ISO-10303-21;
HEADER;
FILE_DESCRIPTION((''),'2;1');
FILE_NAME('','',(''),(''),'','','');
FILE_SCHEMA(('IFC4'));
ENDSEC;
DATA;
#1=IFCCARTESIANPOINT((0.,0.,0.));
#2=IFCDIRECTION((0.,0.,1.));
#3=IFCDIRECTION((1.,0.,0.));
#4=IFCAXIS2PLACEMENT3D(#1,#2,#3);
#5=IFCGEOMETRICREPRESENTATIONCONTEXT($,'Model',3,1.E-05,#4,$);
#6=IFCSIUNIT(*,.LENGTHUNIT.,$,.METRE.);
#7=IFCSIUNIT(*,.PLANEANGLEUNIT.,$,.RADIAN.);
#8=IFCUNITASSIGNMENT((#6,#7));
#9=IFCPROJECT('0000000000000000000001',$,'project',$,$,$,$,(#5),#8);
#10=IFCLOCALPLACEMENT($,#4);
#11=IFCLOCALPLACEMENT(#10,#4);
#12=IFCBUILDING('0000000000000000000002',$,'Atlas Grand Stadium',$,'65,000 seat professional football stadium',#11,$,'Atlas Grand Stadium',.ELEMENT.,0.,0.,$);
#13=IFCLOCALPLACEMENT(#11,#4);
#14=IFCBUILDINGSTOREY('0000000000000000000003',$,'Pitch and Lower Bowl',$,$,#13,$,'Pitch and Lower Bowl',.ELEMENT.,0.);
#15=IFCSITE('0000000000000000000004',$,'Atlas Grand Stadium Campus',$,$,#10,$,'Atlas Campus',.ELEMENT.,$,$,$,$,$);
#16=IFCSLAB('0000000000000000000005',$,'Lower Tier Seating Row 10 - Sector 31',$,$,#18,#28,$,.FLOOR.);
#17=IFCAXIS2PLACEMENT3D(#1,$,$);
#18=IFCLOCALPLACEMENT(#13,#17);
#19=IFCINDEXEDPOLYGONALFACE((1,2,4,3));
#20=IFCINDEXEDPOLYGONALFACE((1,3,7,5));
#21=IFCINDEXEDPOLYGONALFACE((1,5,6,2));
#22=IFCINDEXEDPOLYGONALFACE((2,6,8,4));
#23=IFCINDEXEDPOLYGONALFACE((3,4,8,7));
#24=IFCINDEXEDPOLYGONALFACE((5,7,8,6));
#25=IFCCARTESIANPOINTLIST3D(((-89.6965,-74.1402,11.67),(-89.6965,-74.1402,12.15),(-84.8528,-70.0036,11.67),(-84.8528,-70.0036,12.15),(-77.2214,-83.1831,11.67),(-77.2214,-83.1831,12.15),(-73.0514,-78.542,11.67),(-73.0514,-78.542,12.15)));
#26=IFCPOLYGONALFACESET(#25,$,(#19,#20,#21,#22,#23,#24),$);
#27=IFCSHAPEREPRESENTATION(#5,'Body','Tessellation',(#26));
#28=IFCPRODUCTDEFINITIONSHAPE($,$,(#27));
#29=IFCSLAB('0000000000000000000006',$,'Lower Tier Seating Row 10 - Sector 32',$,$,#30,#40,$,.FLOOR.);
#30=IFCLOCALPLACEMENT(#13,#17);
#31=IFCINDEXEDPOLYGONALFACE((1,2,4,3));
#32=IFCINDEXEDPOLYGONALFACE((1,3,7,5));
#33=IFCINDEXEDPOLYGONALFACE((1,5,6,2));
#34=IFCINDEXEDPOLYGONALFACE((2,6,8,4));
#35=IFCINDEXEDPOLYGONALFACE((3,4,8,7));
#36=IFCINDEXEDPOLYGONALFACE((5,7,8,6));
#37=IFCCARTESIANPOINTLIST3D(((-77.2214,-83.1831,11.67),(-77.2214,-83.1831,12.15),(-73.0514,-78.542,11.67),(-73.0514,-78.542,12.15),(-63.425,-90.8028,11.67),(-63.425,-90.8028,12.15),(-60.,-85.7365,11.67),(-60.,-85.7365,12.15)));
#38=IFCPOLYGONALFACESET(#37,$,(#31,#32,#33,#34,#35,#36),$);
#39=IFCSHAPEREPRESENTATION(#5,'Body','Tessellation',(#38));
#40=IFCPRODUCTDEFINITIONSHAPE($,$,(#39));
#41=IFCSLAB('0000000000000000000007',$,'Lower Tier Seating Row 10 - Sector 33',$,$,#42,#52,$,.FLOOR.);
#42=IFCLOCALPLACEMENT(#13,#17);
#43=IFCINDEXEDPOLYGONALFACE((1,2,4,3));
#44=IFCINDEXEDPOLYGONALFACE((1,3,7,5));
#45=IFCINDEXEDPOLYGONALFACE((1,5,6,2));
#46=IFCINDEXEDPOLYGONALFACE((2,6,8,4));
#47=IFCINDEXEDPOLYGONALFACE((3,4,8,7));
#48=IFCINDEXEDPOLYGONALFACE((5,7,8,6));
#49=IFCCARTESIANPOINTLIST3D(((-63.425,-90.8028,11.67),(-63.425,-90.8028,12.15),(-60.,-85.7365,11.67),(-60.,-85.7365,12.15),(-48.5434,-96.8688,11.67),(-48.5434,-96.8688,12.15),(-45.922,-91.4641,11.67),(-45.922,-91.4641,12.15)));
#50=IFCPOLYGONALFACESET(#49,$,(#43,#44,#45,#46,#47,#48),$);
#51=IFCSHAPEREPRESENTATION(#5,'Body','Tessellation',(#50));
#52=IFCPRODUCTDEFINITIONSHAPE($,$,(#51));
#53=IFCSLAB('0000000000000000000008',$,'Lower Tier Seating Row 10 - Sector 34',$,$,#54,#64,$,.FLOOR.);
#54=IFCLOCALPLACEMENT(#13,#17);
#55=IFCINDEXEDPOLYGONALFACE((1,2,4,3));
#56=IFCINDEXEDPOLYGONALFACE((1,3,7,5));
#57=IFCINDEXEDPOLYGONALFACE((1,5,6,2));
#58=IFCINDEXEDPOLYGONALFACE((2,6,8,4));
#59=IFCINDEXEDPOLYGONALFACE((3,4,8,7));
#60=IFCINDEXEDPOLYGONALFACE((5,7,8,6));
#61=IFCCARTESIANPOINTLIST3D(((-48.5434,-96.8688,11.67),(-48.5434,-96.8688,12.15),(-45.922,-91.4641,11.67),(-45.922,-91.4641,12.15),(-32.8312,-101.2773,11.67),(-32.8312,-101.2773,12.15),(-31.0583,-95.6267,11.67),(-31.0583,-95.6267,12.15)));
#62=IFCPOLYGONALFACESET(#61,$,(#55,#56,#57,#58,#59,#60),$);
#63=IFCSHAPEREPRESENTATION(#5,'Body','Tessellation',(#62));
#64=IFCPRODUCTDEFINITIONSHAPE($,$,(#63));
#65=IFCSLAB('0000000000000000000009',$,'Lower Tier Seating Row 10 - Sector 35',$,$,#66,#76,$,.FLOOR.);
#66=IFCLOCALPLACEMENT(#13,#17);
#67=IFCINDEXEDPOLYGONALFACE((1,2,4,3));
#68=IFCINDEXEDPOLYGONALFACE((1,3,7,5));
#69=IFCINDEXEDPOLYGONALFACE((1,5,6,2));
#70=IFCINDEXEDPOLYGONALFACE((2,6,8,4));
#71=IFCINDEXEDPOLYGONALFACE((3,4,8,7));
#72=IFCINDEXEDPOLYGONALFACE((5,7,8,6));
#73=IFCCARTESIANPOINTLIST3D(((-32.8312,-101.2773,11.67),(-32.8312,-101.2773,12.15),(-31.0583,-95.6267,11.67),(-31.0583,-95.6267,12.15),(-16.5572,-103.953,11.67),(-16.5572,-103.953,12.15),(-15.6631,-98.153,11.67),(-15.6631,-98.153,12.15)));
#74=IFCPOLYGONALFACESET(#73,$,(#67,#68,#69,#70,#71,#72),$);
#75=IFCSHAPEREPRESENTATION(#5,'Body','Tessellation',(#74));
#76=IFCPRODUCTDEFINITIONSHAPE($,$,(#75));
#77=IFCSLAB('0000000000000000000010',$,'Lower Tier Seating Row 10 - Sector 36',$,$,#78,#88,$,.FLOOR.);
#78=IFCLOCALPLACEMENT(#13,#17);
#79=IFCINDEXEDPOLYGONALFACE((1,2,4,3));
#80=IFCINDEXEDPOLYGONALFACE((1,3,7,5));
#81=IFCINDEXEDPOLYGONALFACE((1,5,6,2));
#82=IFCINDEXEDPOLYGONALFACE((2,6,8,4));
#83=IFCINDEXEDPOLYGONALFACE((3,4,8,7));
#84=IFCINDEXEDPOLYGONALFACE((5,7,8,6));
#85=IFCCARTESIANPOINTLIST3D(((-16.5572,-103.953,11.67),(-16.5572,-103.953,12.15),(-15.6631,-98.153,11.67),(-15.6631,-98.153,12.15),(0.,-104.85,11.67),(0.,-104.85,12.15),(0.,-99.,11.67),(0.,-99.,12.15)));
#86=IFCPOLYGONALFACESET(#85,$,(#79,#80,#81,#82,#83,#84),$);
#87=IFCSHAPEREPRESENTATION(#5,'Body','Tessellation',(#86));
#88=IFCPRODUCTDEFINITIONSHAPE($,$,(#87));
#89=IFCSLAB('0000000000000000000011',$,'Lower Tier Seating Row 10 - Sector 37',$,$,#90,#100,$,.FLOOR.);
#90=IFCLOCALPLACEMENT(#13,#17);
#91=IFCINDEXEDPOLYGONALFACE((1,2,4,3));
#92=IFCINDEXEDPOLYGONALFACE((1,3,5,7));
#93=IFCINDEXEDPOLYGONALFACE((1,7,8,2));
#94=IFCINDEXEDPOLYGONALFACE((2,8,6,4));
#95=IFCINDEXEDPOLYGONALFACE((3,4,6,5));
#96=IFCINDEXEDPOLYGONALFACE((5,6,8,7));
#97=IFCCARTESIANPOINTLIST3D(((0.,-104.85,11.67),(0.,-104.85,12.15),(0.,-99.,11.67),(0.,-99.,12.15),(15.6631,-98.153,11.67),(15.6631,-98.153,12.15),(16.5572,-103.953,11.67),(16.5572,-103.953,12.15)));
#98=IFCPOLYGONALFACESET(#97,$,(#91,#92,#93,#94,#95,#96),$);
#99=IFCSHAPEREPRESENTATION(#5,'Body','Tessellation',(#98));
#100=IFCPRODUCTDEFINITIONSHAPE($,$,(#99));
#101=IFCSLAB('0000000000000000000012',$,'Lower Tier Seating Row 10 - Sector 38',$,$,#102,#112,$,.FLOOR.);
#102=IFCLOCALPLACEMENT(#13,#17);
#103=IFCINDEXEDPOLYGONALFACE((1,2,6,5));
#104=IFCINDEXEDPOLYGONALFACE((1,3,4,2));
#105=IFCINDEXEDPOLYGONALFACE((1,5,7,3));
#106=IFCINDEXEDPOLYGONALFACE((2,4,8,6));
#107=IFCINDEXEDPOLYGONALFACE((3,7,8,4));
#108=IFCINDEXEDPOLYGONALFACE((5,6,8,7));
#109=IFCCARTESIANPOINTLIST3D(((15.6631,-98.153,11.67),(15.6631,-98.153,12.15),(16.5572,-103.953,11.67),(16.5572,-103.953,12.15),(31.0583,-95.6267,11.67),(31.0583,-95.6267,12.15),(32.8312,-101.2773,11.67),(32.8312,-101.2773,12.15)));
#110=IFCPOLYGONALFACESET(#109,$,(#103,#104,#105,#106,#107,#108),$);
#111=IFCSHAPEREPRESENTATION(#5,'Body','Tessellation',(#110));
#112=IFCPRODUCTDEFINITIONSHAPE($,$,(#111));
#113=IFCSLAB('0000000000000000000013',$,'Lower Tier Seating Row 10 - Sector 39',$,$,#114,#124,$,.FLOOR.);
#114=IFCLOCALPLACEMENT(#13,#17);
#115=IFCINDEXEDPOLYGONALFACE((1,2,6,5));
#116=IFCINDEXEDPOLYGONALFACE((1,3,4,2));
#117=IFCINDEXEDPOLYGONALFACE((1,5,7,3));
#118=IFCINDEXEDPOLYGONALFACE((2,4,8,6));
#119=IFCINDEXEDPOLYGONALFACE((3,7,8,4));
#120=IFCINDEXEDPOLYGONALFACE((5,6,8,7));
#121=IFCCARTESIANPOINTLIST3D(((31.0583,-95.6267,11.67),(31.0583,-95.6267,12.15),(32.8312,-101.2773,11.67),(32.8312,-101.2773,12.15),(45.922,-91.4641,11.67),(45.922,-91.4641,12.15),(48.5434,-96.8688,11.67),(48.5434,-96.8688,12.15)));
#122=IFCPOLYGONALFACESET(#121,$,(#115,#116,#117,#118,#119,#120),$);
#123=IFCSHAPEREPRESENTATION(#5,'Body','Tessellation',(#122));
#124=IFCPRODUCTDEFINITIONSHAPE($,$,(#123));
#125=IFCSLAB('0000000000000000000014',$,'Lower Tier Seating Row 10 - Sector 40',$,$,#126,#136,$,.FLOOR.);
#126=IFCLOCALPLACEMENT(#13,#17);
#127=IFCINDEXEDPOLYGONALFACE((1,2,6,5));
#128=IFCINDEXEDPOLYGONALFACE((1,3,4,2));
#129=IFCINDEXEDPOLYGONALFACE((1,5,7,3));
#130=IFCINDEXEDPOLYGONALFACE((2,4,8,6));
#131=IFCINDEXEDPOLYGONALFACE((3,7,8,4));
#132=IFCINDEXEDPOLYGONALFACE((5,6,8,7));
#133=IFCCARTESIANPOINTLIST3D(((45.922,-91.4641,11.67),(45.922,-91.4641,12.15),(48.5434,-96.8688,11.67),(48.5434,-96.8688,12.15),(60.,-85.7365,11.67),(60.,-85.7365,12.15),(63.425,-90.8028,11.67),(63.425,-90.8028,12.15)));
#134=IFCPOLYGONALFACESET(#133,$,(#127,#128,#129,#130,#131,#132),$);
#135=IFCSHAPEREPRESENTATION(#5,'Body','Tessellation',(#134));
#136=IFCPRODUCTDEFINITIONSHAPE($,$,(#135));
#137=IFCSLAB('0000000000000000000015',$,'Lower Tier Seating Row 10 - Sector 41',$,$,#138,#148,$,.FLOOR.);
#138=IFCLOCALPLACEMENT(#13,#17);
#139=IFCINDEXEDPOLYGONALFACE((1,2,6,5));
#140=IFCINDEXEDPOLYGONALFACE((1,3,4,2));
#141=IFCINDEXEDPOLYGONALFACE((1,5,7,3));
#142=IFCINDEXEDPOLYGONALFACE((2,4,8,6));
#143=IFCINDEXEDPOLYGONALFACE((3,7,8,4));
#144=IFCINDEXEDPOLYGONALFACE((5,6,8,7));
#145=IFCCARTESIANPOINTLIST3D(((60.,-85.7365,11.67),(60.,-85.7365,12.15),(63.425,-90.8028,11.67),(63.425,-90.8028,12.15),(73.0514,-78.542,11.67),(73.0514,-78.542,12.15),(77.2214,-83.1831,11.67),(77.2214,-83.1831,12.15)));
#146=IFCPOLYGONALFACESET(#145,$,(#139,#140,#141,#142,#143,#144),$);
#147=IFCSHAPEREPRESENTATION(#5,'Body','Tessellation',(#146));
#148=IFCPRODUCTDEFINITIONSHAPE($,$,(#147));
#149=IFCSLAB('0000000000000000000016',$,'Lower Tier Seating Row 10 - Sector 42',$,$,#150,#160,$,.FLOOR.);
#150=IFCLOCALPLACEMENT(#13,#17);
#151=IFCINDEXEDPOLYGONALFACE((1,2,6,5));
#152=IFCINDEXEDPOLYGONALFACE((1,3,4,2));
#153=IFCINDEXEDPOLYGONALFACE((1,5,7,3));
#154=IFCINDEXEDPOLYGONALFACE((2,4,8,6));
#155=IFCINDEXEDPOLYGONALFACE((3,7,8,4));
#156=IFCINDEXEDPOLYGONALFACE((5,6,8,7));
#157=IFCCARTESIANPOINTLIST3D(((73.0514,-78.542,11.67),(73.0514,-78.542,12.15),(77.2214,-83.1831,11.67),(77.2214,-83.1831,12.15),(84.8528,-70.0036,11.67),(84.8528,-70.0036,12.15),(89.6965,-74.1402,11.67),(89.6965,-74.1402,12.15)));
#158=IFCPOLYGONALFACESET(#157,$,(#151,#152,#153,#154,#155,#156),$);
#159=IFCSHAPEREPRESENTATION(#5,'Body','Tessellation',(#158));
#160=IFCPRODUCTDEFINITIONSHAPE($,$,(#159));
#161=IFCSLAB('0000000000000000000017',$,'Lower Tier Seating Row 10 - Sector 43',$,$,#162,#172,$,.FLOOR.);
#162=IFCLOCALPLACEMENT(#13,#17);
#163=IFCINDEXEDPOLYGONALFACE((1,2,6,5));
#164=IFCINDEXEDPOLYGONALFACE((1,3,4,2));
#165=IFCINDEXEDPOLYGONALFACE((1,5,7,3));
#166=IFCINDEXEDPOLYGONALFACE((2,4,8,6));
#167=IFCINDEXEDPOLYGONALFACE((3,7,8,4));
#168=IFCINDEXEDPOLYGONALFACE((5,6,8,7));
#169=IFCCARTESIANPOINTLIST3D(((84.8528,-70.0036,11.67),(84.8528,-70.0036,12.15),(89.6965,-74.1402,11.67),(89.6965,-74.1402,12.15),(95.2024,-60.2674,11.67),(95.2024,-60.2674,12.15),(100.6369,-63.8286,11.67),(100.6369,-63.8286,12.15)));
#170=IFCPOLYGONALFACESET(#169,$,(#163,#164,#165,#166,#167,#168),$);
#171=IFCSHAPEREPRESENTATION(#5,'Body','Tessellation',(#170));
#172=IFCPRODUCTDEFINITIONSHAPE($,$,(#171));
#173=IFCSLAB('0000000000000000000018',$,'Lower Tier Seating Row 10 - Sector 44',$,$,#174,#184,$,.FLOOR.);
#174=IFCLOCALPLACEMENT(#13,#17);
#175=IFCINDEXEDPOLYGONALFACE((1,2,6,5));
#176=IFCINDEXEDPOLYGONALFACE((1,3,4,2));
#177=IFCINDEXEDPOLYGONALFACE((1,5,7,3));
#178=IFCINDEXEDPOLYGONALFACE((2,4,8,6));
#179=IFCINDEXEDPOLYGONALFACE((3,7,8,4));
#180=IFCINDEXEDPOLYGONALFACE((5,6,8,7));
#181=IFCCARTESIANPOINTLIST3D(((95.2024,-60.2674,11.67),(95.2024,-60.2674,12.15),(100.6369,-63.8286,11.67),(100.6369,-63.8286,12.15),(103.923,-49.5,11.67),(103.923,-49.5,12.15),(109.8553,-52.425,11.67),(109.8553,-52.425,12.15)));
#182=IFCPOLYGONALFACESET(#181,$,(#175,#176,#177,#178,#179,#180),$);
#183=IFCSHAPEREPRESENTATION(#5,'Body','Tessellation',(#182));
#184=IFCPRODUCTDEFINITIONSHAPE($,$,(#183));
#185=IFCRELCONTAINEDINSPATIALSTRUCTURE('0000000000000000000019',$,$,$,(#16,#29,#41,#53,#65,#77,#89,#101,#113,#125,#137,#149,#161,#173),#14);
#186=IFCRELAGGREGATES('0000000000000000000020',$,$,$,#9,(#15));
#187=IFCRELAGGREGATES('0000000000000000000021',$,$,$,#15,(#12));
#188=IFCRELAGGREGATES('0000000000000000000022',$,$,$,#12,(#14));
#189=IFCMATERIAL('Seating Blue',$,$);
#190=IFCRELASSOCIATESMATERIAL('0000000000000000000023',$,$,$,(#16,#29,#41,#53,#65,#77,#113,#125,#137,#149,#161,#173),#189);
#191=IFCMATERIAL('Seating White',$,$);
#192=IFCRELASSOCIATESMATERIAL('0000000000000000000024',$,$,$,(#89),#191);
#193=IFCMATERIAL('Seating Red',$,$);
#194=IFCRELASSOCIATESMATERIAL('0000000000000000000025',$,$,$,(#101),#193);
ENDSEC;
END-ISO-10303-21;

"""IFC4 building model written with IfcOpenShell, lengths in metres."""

from ifc_helpers import new_model, si_unit, frame, origin_with_axes, place, context, project, spatial, polyline, outline, extrude, material, element, save


model = new_model("IFC4")

# Units and contexts
model_context = context("Model", 3, precision=1e-05, world=origin_with_axes())
ifc_project = project(units=[si_unit("LENGTHUNIT", "METRE"), si_unit("PLANEANGLEUNIT", "RADIAN")], contexts=[model_context])

# Site, building, storey
site_placement = place(None, origin_with_axes())
site = spatial("IfcSite", under=ifc_project, at=site_placement, Name="Atlas Grand Stadium Campus", LongName="Atlas Campus", CompositionType="ELEMENT")
building_placement = place(site_placement, origin_with_axes())
building = spatial("IfcBuilding", under=site, at=building_placement, Name="Atlas Grand Stadium", ObjectType="65,000 seat professional football stadium", LongName="Atlas Grand Stadium", CompositionType="ELEMENT", ElevationOfRefHeight=0.0, ElevationOfTerrain=0.0)
storey_placement = place(building_placement, origin_with_axes())
storey = spatial("IfcBuildingStorey", under=building, at=storey_placement, Name="Pitch and Lower Bowl", LongName="Pitch and Lower Bowl", CompositionType="ELEMENT", Elevation=0.0)

# Slabs
ifc_material_1 = material(Name="Seating Blue")
ifc_material_2 = material(Name="Seating Red")
ifc_material_3 = material(Name="Seating White")
slab_1_placement = place(storey_placement, frame((0.0, 0.0, 11.67), z_axis=(0.0, 0.0, 1.0), x_axis=(1.0, 0.0, 0.0)))
element("IfcSlab", 1, at=slab_1_placement, inside=storey, material=ifc_material_1, Name="Lower Tier Seating Row 10 - Sector 31", PredefinedType="FLOOR", context=model_context, shape_type="SweptSolid", body=[
    extrude(outline(polyline([(-89.6965, -74.1402), (-77.2214, -83.1831), (-73.0514, -78.542), (-84.8528, -70.0036), (-89.6965, -74.1402)])), origin_with_axes(), (0.0, 0.0, 1.0), 0.48),
])
slab_2_placement = place(storey_placement, frame((0.0, 0.0, 11.67), z_axis=(0.0, 0.0, 1.0), x_axis=(1.0, 0.0, 0.0)))
element("IfcSlab", 2, at=slab_2_placement, inside=storey, material=ifc_material_1, Name="Lower Tier Seating Row 10 - Sector 32", PredefinedType="FLOOR", context=model_context, shape_type="SweptSolid", body=[
    extrude(outline(polyline([(-77.2214, -83.1831), (-63.425, -90.8028), (-60.0, -85.7365), (-73.0514, -78.542), (-77.2214, -83.1831)])), origin_with_axes(), (0.0, 0.0, 1.0), 0.48),
])
slab_3_placement = place(storey_placement, frame((0.0, 0.0, 11.67), z_axis=(0.0, 0.0, 1.0), x_axis=(1.0, 0.0, 0.0)))
element("IfcSlab", 3, at=slab_3_placement, inside=storey, material=ifc_material_1, Name="Lower Tier Seating Row 10 - Sector 33", PredefinedType="FLOOR", context=model_context, shape_type="SweptSolid", body=[
    extrude(outline(polyline([(-63.425, -90.8028), (-48.5434, -96.8688), (-45.922, -91.4641), (-60.0, -85.7365), (-63.425, -90.8028)])), origin_with_axes(), (0.0, 0.0, 1.0), 0.48),
])
slab_4_placement = place(storey_placement, frame((0.0, 0.0, 11.67), z_axis=(0.0, 0.0, 1.0), x_axis=(1.0, 0.0, 0.0)))
element("IfcSlab", 4, at=slab_4_placement, inside=storey, material=ifc_material_1, Name="Lower Tier Seating Row 10 - Sector 34", PredefinedType="FLOOR", context=model_context, shape_type="SweptSolid", body=[
    extrude(outline(polyline([(-48.5434, -96.8688), (-32.8312, -101.2773), (-31.0583, -95.6267), (-45.922, -91.4641), (-48.5434, -96.8688)])), origin_with_axes(), (0.0, 0.0, 1.0), 0.48),
])
slab_5_placement = place(storey_placement, frame((0.0, 0.0, 11.67), z_axis=(0.0, 0.0, 1.0), x_axis=(1.0, 0.0, 0.0)))
element("IfcSlab", 5, at=slab_5_placement, inside=storey, material=ifc_material_1, Name="Lower Tier Seating Row 10 - Sector 35", PredefinedType="FLOOR", context=model_context, shape_type="SweptSolid", body=[
    extrude(outline(polyline([(-32.8312, -101.2773), (-16.5572, -103.953), (-15.6631, -98.153), (-31.0583, -95.6267), (-32.8312, -101.2773)])), origin_with_axes(), (0.0, 0.0, 1.0), 0.48),
])
slab_6_placement = place(storey_placement, frame((0.0, 0.0, 11.67), z_axis=(0.0, 0.0, 1.0), x_axis=(1.0, 0.0, 0.0)))
element("IfcSlab", 6, at=slab_6_placement, inside=storey, material=ifc_material_1, Name="Lower Tier Seating Row 10 - Sector 36", PredefinedType="FLOOR", context=model_context, shape_type="SweptSolid", body=[
    extrude(outline(polyline([(-16.5572, -103.953), (0.0, -104.85), (0.0, -99.0), (-15.6631, -98.153), (-16.5572, -103.953)])), origin_with_axes(), (0.0, 0.0, 1.0), 0.48),
])
slab_7_placement = place(storey_placement, frame((0.0, 0.0, 11.67), z_axis=(0.0, 0.0, 1.0), x_axis=(1.0, 0.0, 0.0)))
element("IfcSlab", 7, at=slab_7_placement, inside=storey, material=ifc_material_3, Name="Lower Tier Seating Row 10 - Sector 37", PredefinedType="FLOOR", context=model_context, shape_type="SweptSolid", body=[
    extrude(outline(polyline([(0.0, -104.85), (16.5572, -103.953), (15.6631, -98.153), (0.0, -99.0), (0.0, -104.85)])), origin_with_axes(), (0.0, 0.0, 1.0), 0.48),
])
slab_8_placement = place(storey_placement, frame((0.0, 0.0, 11.67), z_axis=(0.0, 0.0, 1.0), x_axis=(1.0, 0.0, 0.0)))
element("IfcSlab", 8, at=slab_8_placement, inside=storey, material=ifc_material_2, Name="Lower Tier Seating Row 10 - Sector 38", PredefinedType="FLOOR", context=model_context, shape_type="SweptSolid", body=[
    extrude(outline(polyline([(16.5572, -103.953), (32.8312, -101.2773), (31.0583, -95.6267), (15.6631, -98.153), (16.5572, -103.953)])), origin_with_axes(), (0.0, 0.0, 1.0), 0.48),
])
slab_9_placement = place(storey_placement, frame((0.0, 0.0, 11.67), z_axis=(0.0, 0.0, 1.0), x_axis=(1.0, 0.0, 0.0)))
element("IfcSlab", 9, at=slab_9_placement, inside=storey, material=ifc_material_1, Name="Lower Tier Seating Row 10 - Sector 39", PredefinedType="FLOOR", context=model_context, shape_type="SweptSolid", body=[
    extrude(outline(polyline([(32.8312, -101.2773), (48.5434, -96.8688), (45.922, -91.4641), (31.0583, -95.6267), (32.8312, -101.2773)])), origin_with_axes(), (0.0, 0.0, 1.0), 0.48),
])
slab_10_placement = place(storey_placement, frame((0.0, 0.0, 11.67), z_axis=(0.0, 0.0, 1.0), x_axis=(1.0, 0.0, 0.0)))
element("IfcSlab", 10, at=slab_10_placement, inside=storey, material=ifc_material_1, Name="Lower Tier Seating Row 10 - Sector 40", PredefinedType="FLOOR", context=model_context, shape_type="SweptSolid", body=[
    extrude(outline(polyline([(48.5434, -96.8688), (63.425, -90.8028), (60.0, -85.7365), (45.922, -91.4641), (48.5434, -96.8688)])), origin_with_axes(), (0.0, 0.0, 1.0), 0.48),
])
slab_11_placement = place(storey_placement, frame((0.0, 0.0, 11.67), z_axis=(0.0, 0.0, 1.0), x_axis=(1.0, 0.0, 0.0)))
element("IfcSlab", 11, at=slab_11_placement, inside=storey, material=ifc_material_1, Name="Lower Tier Seating Row 10 - Sector 41", PredefinedType="FLOOR", context=model_context, shape_type="SweptSolid", body=[
    extrude(outline(polyline([(63.425, -90.8028), (77.2214, -83.1831), (73.0514, -78.542), (60.0, -85.7365), (63.425, -90.8028)])), origin_with_axes(), (0.0, 0.0, 1.0), 0.48),
])
slab_12_placement = place(storey_placement, frame((0.0, 0.0, 11.67), z_axis=(0.0, 0.0, 1.0), x_axis=(1.0, 0.0, 0.0)))
element("IfcSlab", 12, at=slab_12_placement, inside=storey, material=ifc_material_1, Name="Lower Tier Seating Row 10 - Sector 42", PredefinedType="FLOOR", context=model_context, shape_type="SweptSolid", body=[
    extrude(outline(polyline([(77.2214, -83.1831), (89.6965, -74.1402), (84.8528, -70.0036), (73.0514, -78.542), (77.2214, -83.1831)])), origin_with_axes(), (0.0, 0.0, 1.0), 0.48),
])
slab_13_placement = place(storey_placement, frame((0.0, 0.0, 11.67), z_axis=(0.0, 0.0, 1.0), x_axis=(1.0, 0.0, 0.0)))
element("IfcSlab", 13, at=slab_13_placement, inside=storey, material=ifc_material_1, Name="Lower Tier Seating Row 10 - Sector 43", PredefinedType="FLOOR", context=model_context, shape_type="SweptSolid", body=[
    extrude(outline(polyline([(89.6965, -74.1402), (100.6369, -63.8286), (95.2024, -60.2674), (84.8528, -70.0036), (89.6965, -74.1402)])), origin_with_axes(), (0.0, 0.0, 1.0), 0.48),
])
slab_14_placement = place(storey_placement, frame((0.0, 0.0, 11.67), z_axis=(0.0, 0.0, 1.0), x_axis=(1.0, 0.0, 0.0)))
element("IfcSlab", 14, at=slab_14_placement, inside=storey, material=ifc_material_1, Name="Lower Tier Seating Row 10 - Sector 44", PredefinedType="FLOOR", context=model_context, shape_type="SweptSolid", body=[
    extrude(outline(polyline([(100.6369, -63.8286), (109.8553, -52.425), (103.9231, -49.5), (95.2024, -60.2674), (100.6369, -63.8286)])), origin_with_axes(), (0.0, 0.0, 1.0), 0.48),
])

save(model, "model.ifc")
